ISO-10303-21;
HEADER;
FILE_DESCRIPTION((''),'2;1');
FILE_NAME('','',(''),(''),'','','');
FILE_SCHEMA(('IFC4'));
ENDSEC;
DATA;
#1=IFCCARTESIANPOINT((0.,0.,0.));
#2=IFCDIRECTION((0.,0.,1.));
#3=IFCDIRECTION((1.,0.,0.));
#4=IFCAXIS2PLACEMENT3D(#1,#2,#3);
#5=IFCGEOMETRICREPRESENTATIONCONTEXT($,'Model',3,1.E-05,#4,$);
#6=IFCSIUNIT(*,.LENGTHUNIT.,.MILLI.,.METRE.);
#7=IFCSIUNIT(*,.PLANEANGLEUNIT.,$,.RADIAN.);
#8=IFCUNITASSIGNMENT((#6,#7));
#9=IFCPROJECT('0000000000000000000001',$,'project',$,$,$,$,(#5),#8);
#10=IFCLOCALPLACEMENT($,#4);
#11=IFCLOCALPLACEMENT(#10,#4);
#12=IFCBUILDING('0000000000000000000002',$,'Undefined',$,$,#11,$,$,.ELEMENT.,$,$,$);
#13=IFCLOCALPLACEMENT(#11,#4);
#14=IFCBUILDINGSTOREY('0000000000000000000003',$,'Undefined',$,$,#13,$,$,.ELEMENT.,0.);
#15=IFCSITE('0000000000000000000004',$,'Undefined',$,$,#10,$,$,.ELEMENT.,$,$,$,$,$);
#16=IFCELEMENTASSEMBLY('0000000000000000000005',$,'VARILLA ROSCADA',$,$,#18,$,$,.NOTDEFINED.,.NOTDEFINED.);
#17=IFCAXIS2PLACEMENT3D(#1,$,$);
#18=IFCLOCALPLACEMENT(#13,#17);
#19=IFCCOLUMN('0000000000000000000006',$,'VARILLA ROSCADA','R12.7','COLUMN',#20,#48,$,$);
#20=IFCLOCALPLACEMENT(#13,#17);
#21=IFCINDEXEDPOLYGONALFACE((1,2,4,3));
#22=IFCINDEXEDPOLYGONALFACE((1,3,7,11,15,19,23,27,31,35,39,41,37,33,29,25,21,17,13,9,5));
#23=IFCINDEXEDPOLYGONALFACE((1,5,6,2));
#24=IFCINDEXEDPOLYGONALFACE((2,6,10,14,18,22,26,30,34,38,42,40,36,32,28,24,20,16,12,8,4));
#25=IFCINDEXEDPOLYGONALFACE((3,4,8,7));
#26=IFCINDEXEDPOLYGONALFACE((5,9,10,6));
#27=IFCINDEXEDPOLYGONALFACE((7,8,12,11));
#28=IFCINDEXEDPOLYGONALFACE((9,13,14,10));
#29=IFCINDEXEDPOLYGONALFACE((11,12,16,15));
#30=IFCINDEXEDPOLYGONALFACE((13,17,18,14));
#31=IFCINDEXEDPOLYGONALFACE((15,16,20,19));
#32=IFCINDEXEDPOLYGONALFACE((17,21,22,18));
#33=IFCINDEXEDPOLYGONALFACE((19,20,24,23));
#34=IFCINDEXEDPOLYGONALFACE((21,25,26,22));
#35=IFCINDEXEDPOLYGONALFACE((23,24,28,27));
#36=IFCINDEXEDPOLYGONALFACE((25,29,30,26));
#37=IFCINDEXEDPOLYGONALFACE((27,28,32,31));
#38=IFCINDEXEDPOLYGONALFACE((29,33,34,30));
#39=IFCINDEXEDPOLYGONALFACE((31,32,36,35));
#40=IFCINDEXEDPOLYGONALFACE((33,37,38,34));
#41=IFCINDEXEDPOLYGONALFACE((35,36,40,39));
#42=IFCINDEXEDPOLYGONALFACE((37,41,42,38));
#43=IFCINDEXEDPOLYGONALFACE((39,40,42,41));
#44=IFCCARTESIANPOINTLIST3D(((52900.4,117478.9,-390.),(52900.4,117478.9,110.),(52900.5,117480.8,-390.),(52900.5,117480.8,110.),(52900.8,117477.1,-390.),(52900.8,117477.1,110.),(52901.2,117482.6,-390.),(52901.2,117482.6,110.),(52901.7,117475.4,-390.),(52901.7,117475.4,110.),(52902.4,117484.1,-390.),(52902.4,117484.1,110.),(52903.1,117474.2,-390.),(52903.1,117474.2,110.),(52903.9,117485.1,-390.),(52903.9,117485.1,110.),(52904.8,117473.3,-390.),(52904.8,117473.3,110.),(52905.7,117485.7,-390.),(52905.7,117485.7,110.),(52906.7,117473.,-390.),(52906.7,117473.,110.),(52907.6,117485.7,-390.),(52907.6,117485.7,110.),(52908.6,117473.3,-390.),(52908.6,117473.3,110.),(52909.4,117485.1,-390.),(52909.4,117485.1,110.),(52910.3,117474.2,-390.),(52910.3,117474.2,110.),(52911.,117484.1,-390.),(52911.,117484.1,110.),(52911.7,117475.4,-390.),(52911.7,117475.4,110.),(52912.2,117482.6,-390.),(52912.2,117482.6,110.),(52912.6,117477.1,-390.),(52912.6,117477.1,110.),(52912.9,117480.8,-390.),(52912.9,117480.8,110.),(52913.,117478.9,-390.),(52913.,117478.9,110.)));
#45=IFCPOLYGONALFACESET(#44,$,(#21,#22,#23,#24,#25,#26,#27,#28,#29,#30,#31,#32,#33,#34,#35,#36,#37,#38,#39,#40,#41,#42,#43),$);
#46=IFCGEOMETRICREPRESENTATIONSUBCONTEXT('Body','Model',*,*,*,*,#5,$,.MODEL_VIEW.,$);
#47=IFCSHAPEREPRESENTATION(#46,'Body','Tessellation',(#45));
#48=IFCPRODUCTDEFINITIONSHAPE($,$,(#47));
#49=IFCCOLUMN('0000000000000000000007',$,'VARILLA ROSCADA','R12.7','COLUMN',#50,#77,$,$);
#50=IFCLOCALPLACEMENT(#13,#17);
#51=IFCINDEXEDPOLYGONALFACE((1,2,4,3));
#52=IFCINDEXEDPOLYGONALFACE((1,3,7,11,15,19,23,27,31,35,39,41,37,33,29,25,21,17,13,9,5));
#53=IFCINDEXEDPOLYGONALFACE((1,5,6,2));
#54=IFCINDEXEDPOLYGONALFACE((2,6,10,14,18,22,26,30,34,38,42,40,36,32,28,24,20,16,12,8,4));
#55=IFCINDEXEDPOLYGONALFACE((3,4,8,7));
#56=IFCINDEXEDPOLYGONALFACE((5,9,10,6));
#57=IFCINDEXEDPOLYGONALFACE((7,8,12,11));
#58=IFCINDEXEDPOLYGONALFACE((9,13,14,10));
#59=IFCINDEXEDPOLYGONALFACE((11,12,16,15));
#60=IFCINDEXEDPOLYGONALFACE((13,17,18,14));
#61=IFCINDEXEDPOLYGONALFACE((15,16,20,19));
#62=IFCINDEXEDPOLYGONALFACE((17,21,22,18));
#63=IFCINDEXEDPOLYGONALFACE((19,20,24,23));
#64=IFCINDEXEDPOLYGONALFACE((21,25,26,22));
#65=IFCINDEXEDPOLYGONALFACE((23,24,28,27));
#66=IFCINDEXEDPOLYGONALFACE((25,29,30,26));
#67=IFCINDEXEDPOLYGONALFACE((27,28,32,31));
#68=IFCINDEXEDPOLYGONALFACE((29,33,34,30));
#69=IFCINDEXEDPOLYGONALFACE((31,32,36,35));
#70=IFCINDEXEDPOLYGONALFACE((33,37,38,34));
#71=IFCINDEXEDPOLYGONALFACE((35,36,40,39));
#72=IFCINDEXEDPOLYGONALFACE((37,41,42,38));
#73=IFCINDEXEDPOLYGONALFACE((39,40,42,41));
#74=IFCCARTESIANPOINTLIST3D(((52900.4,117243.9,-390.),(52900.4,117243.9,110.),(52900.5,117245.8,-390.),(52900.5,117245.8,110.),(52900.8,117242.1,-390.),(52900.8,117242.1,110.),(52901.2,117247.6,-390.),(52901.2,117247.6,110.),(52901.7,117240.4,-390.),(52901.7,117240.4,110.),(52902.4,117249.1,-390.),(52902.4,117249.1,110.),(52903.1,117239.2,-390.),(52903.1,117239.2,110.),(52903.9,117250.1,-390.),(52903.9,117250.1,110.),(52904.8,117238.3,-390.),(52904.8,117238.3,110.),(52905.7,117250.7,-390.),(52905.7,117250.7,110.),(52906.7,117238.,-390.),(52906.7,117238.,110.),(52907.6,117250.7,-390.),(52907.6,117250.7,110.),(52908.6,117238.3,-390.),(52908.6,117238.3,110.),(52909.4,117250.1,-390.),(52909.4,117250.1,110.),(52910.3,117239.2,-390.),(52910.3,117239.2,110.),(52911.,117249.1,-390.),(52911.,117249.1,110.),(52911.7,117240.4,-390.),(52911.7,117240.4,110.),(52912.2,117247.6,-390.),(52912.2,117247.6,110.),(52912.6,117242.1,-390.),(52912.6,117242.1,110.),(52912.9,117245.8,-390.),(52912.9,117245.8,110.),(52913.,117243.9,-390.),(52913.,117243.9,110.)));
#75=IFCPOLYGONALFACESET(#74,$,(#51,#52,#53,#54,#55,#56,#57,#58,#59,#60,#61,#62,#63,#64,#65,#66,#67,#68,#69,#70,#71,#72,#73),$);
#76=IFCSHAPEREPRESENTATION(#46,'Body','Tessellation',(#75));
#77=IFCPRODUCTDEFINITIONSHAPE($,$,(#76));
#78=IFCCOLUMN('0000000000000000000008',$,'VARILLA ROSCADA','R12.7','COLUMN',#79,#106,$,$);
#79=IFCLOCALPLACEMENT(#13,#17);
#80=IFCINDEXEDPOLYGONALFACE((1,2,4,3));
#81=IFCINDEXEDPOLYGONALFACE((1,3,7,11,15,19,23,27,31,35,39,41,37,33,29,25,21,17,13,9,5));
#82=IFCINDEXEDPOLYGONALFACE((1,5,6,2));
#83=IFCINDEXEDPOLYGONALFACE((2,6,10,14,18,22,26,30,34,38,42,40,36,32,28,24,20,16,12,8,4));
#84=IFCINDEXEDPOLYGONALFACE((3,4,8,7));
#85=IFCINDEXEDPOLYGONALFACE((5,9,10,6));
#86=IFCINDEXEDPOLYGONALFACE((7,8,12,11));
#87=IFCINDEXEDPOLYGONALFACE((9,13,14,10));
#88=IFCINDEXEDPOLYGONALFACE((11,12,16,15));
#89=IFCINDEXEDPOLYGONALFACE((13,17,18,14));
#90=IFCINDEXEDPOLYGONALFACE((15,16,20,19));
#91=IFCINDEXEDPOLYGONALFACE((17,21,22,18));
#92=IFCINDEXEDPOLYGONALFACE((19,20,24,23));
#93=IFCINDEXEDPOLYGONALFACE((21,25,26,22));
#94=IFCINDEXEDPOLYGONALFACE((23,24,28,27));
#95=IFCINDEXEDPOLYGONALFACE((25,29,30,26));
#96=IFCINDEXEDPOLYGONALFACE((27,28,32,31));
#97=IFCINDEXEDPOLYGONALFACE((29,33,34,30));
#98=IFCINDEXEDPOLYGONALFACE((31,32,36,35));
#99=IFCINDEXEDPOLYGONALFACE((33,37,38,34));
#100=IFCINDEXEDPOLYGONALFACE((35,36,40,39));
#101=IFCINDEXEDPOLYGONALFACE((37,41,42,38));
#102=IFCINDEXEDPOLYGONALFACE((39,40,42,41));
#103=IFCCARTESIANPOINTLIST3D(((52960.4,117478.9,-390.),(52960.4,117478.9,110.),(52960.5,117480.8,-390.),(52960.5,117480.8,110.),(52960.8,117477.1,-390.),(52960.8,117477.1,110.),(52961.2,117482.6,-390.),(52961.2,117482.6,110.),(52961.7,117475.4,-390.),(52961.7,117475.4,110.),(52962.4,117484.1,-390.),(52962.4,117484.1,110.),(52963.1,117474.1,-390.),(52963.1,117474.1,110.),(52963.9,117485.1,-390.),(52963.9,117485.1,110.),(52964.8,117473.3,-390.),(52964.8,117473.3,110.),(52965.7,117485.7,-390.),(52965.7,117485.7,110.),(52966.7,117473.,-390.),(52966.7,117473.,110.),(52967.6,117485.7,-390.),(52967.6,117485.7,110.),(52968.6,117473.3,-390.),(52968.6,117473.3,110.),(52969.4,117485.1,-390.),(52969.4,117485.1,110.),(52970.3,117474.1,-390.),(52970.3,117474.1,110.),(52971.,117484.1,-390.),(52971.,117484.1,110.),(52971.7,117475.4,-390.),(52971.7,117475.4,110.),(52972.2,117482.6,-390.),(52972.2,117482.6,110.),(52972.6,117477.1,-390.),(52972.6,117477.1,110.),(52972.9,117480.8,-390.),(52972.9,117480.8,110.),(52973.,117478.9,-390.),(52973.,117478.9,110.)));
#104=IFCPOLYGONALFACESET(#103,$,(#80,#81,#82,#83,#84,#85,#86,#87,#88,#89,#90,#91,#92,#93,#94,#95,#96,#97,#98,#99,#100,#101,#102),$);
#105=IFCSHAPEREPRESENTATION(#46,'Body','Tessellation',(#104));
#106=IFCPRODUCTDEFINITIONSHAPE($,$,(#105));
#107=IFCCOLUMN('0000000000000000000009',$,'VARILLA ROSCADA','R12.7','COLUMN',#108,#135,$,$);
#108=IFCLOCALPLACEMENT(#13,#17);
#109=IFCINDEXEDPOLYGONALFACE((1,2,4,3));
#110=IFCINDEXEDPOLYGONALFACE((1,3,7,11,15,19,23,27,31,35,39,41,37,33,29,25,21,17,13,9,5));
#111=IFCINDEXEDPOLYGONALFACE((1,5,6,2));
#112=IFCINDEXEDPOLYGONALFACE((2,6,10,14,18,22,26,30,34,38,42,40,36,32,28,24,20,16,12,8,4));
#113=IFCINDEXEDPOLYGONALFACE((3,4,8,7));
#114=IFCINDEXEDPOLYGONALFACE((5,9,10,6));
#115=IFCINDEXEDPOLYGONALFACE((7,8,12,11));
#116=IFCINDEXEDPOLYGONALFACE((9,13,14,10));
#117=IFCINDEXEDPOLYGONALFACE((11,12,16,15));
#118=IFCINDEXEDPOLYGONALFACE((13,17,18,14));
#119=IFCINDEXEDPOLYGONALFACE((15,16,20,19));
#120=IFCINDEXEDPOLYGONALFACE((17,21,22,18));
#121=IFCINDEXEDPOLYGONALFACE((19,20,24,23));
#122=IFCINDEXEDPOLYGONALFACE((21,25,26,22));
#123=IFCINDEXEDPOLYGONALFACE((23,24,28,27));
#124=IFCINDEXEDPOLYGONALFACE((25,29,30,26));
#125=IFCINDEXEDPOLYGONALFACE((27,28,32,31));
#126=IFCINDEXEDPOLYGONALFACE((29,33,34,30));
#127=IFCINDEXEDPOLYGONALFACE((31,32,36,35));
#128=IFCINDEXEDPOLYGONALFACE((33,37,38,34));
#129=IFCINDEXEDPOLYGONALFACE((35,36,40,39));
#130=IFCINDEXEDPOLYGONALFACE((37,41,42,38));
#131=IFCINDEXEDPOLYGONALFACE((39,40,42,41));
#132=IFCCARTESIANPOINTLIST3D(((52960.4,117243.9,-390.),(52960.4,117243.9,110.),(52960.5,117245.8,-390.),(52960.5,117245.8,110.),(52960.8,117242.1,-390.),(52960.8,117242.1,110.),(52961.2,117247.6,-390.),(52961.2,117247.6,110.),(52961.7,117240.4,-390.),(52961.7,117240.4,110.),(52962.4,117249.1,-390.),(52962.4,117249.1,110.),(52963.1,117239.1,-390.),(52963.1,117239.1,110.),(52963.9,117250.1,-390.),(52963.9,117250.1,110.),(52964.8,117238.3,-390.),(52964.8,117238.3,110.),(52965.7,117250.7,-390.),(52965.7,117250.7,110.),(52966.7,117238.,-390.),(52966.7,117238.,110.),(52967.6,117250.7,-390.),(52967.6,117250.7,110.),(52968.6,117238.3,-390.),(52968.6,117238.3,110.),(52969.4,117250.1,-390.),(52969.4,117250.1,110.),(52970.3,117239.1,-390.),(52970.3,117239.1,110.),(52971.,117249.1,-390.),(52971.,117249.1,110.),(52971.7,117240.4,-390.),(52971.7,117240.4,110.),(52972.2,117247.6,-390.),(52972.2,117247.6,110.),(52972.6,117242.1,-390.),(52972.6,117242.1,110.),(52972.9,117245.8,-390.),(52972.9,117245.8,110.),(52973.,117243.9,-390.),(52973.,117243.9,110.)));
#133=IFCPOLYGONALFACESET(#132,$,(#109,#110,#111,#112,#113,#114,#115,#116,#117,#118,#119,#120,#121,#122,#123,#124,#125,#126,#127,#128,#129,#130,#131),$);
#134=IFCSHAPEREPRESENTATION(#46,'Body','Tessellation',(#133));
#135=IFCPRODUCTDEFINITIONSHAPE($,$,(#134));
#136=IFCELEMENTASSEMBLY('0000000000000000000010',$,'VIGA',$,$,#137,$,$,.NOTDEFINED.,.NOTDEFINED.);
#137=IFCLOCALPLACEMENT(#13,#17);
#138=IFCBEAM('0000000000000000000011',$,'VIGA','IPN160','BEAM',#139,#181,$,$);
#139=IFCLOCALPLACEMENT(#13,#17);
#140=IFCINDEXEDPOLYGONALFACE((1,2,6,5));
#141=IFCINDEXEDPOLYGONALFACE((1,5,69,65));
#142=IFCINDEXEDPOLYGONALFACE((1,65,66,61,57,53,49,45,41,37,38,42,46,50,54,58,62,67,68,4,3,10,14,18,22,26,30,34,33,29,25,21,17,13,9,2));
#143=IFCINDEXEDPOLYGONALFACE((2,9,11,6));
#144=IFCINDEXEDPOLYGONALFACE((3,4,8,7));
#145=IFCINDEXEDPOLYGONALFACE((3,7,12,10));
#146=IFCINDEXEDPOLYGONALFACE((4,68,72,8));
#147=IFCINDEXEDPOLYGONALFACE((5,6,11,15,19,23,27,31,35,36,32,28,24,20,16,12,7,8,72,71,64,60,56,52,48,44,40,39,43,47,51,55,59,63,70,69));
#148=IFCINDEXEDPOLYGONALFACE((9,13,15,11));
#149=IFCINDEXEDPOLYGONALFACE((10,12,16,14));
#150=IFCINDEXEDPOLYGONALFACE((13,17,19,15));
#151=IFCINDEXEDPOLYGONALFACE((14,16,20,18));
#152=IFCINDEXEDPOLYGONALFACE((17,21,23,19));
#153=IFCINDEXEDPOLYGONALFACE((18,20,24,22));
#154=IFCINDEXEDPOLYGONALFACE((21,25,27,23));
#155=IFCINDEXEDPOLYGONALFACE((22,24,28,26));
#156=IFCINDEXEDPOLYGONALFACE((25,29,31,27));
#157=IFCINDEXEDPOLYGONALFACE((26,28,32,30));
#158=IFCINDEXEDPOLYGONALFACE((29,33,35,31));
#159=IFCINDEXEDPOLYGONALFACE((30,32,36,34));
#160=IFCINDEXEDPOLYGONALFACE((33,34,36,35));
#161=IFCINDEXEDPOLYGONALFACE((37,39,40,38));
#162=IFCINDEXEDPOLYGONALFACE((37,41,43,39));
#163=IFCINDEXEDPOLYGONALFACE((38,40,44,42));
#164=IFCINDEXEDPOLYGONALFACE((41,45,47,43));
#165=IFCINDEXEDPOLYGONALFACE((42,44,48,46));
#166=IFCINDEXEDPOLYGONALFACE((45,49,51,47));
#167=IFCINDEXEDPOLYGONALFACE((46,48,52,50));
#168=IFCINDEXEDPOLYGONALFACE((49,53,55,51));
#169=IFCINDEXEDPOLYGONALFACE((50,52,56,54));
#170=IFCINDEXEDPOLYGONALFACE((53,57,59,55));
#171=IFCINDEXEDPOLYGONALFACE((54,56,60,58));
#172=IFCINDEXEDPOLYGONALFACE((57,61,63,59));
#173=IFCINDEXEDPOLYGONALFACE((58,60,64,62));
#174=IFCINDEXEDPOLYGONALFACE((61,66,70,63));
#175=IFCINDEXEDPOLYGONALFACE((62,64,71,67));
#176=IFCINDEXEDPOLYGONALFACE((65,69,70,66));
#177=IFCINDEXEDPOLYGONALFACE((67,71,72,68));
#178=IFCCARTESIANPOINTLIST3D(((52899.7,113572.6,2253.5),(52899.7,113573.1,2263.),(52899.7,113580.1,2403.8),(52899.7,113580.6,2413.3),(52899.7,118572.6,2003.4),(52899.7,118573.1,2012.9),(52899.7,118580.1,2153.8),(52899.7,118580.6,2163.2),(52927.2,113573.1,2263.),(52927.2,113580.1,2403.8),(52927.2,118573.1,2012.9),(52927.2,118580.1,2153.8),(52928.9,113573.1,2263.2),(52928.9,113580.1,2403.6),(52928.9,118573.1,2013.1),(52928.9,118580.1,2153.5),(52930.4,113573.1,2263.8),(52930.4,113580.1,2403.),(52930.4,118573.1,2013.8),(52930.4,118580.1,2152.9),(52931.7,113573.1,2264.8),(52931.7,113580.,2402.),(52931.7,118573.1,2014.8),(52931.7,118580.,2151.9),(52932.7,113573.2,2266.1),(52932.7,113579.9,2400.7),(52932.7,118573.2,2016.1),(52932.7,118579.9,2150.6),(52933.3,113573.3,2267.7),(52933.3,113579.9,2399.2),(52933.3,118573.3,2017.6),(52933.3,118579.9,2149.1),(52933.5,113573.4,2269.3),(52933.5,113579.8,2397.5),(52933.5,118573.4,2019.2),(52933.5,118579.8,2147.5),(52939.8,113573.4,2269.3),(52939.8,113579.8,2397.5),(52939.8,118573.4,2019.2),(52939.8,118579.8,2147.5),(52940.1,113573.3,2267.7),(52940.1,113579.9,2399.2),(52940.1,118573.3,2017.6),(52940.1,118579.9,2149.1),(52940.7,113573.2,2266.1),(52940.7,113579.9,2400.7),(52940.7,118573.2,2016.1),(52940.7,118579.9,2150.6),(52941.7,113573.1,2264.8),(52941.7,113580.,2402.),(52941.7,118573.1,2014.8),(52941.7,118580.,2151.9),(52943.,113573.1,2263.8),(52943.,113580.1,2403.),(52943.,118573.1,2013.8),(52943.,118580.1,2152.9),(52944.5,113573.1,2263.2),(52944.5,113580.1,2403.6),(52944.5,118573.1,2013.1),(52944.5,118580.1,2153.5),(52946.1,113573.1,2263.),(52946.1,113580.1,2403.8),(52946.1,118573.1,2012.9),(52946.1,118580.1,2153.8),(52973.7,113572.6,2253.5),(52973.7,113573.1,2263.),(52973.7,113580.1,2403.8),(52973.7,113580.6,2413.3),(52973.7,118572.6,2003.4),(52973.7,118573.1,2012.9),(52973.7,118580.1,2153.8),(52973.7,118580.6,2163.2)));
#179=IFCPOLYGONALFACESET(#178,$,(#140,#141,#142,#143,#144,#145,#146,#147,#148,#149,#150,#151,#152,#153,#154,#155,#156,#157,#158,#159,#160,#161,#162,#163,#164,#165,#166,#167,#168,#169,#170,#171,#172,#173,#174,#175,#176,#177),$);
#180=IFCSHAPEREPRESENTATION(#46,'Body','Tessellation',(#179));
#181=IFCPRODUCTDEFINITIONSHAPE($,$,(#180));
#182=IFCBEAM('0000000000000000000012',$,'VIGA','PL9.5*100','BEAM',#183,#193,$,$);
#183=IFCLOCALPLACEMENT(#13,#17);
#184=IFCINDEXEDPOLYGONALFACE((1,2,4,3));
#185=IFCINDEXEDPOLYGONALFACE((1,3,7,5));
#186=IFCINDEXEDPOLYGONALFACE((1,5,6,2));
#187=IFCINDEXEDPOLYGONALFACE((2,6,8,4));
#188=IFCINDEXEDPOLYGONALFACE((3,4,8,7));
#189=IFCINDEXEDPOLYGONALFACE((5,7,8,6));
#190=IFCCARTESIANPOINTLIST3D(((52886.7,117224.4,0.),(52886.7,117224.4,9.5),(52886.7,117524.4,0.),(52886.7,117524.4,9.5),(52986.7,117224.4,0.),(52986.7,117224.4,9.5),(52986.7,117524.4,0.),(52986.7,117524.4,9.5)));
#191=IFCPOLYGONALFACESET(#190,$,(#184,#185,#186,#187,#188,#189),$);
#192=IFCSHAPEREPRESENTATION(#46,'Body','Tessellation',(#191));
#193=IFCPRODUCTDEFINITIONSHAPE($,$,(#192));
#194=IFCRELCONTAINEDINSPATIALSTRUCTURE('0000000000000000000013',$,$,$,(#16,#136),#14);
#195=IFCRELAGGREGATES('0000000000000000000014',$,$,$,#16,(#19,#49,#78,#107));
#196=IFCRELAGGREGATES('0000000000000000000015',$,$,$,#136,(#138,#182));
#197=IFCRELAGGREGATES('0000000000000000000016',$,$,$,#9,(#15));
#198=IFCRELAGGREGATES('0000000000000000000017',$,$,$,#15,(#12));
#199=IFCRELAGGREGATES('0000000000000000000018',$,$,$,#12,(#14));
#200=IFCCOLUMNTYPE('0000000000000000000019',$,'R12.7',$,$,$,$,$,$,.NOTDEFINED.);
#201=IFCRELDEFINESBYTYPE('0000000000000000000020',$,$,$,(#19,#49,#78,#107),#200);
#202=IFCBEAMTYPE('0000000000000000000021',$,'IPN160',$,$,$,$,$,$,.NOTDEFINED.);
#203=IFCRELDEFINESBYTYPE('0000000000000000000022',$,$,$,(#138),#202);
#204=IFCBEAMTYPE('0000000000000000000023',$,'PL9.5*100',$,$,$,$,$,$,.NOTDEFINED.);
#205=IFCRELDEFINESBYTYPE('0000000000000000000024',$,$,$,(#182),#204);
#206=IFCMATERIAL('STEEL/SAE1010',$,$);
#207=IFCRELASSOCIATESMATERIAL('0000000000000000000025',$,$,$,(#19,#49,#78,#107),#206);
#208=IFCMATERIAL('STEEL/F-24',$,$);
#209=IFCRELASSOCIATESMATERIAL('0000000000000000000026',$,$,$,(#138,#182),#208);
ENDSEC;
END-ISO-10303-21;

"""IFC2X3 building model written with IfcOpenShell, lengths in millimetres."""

from ifc_helpers import new_model, si_unit, frame, origin_with_axes, origin_2d_with_axis, place, context, subcontext, project, spatial, rectangle, circle, i_section, extrude, material, type_object, element, aggregate, save


model = new_model("IFC2X3")

# Units and contexts
model_context = context("Model", 3, precision=1e-05, world=origin_with_axes())
body_context = subcontext(model_context, "Body", "Model", "MODEL_VIEW")
ifc_project = project(units=[si_unit("LENGTHUNIT", "METRE", prefix="MILLI"), si_unit("PLANEANGLEUNIT", "RADIAN")], contexts=[model_context])

# Site, building, storey
site_placement = place(None, origin_with_axes())
site = spatial("IfcSite", under=ifc_project, at=site_placement, Name="Undefined", CompositionType="ELEMENT")
building_placement = place(site_placement, origin_with_axes())
building = spatial("IfcBuilding", under=site, at=building_placement, Name="Undefined", CompositionType="ELEMENT")
storey_placement = place(building_placement, origin_with_axes())
storey = spatial("IfcBuildingStorey", under=building, at=storey_placement, Name="Undefined", CompositionType="ELEMENT", Elevation=0.0)

# Element assembly, columns
assembly_1_placement = place(storey_placement, origin_with_axes())
assembly_1 = element("IfcElementAssembly", 1, at=assembly_1_placement, inside=storey, Name="VARILLA ROSCADA", AssemblyPlace="NOTDEFINED", PredefinedType="NOTDEFINED")
ifc_material_1 = material(Name="STEEL/SAE1010")
column_type = type_object("IfcColumnType", Name="R12.7", PredefinedType="NOTDEFINED")
column_1_placement = place(assembly_1_placement, frame((52906.7, 117479.4, -390.0), z_axis=(0.0, 0.0, 1.0), x_axis=(-1.0, 0.0, 0.0)))
column_1 = element("IfcColumn", 2, at=column_1_placement, type_object=column_type, material=ifc_material_1, Name="VARILLA ROSCADA", Description="R12.7", ObjectType="COLUMN", context=body_context, shape_type="SweptSolid", body=[
    extrude(circle(Radius=6.3, at=origin_2d_with_axis()), frame((0.0, 0.0, 500.0), z_axis=(0.0, 0.0, -1.0), x_axis=(0.0, 1.0, 0.0)), (0.0, 0.0, 1.0), 500.0),
])
column_2_placement = place(assembly_1_placement, frame((52906.7, 117244.4, -390.0), z_axis=(0.0, 0.0, 1.0), x_axis=(-1.0, 0.0, 0.0)))
column_2 = element("IfcColumn", 3, at=column_2_placement, type_object=column_type, material=ifc_material_1, Name="VARILLA ROSCADA", Description="R12.7", ObjectType="COLUMN", context=body_context, shape_type="SweptSolid", body=[
    extrude(circle(Radius=6.3, at=origin_2d_with_axis()), frame((0.0, 0.0, 500.0), z_axis=(0.0, 0.0, -1.0), x_axis=(0.0, 1.0, 0.0)), (0.0, 0.0, 1.0), 500.0),
])
column_3_placement = place(assembly_1_placement, frame((52966.7, 117479.4, -390.0), z_axis=(0.0, 0.0, 1.0), x_axis=(-1.0, 0.0, 0.0)))
column_3 = element("IfcColumn", 4, at=column_3_placement, type_object=column_type, material=ifc_material_1, Name="VARILLA ROSCADA", Description="R12.7", ObjectType="COLUMN", context=body_context, shape_type="SweptSolid", body=[
    extrude(circle(Radius=6.3, at=origin_2d_with_axis()), frame((0.0, 0.0, 500.0), z_axis=(0.0, 0.0, -1.0), x_axis=(0.0, 1.0, 0.0)), (0.0, 0.0, 1.0), 500.0),
])
column_4_placement = place(assembly_1_placement, frame((52966.7, 117244.4, -390.0), z_axis=(0.0, 0.0, 1.0), x_axis=(-1.0, 0.0, 0.0)))
column_4 = element("IfcColumn", 5, at=column_4_placement, type_object=column_type, material=ifc_material_1, Name="VARILLA ROSCADA", Description="R12.7", ObjectType="COLUMN", context=body_context, shape_type="SweptSolid", body=[
    extrude(circle(Radius=6.3, at=origin_2d_with_axis()), frame((0.0, 0.0, 500.0), z_axis=(0.0, 0.0, -1.0), x_axis=(0.0, 1.0, 0.0)), (0.0, 0.0, 1.0), 500.0),
])

# Element assembly, beams
assembly_2_placement = place(storey_placement, origin_with_axes())
assembly_2 = element("IfcElementAssembly", 6, at=assembly_2_placement, inside=storey, Name="VIGA", AssemblyPlace="NOTDEFINED", PredefinedType="NOTDEFINED")
ifc_material_2 = material(Name="STEEL/F-24")
beam_type_1 = type_object("IfcBeamType", Name="IPN160", PredefinedType="NOTDEFINED")
beam_1_placement = place(assembly_2_placement, frame((52936.7, 118576.6, 2083.3), z_axis=(0.0, 0.04995, 0.998752), x_axis=(0.0, -0.998752, 0.04995)))
beam_1 = element("IfcBeam", 7, at=beam_1_placement, type_object=beam_type_1, material=ifc_material_2, Name="VIGA", Description="IPN160", ObjectType="BEAM", context=body_context, shape_type="SweptSolid", body=[
    extrude(i_section(OverallWidth=74.0, OverallDepth=160.0, WebThickness=6.3, FlangeThickness=9.5, FilletRadius=6.3, at=origin_2d_with_axis()), frame((5006.2, 0.0, 0.0), z_axis=(-1.0, 0.0, 0.0), x_axis=(0.0, -1.0, 0.0)), (0.0, 0.0, 1.0), 5006.2),
])
beam_type_2 = type_object("IfcBeamType", Name="PL9.5*100", PredefinedType="NOTDEFINED")
beam_2_placement = place(assembly_2_placement, frame((52936.7, 117524.4, 4.7), z_axis=(1.0, 0.0, 0.0), x_axis=(0.0, -1.0, 0.0)))
beam_2 = element("IfcBeam", 8, at=beam_2_placement, type_object=beam_type_2, material=ifc_material_2, Name="VIGA", Description="PL9.5*100", ObjectType="BEAM", context=body_context, shape_type="SweptSolid", body=[
    extrude(rectangle(XDim=9.5, YDim=100.0, at=origin_2d_with_axis()), frame((300.0, 0.0, 0.0), z_axis=(-1.0, 0.0, 0.0), x_axis=(0.0, -1.0, 0.0)), (0.0, 0.0, 1.0), 300.0),
])

aggregate(assembly_1, [column_1, column_2, column_3, column_4])

aggregate(assembly_2, [beam_1, beam_2])

save(model, "model.ifc")
